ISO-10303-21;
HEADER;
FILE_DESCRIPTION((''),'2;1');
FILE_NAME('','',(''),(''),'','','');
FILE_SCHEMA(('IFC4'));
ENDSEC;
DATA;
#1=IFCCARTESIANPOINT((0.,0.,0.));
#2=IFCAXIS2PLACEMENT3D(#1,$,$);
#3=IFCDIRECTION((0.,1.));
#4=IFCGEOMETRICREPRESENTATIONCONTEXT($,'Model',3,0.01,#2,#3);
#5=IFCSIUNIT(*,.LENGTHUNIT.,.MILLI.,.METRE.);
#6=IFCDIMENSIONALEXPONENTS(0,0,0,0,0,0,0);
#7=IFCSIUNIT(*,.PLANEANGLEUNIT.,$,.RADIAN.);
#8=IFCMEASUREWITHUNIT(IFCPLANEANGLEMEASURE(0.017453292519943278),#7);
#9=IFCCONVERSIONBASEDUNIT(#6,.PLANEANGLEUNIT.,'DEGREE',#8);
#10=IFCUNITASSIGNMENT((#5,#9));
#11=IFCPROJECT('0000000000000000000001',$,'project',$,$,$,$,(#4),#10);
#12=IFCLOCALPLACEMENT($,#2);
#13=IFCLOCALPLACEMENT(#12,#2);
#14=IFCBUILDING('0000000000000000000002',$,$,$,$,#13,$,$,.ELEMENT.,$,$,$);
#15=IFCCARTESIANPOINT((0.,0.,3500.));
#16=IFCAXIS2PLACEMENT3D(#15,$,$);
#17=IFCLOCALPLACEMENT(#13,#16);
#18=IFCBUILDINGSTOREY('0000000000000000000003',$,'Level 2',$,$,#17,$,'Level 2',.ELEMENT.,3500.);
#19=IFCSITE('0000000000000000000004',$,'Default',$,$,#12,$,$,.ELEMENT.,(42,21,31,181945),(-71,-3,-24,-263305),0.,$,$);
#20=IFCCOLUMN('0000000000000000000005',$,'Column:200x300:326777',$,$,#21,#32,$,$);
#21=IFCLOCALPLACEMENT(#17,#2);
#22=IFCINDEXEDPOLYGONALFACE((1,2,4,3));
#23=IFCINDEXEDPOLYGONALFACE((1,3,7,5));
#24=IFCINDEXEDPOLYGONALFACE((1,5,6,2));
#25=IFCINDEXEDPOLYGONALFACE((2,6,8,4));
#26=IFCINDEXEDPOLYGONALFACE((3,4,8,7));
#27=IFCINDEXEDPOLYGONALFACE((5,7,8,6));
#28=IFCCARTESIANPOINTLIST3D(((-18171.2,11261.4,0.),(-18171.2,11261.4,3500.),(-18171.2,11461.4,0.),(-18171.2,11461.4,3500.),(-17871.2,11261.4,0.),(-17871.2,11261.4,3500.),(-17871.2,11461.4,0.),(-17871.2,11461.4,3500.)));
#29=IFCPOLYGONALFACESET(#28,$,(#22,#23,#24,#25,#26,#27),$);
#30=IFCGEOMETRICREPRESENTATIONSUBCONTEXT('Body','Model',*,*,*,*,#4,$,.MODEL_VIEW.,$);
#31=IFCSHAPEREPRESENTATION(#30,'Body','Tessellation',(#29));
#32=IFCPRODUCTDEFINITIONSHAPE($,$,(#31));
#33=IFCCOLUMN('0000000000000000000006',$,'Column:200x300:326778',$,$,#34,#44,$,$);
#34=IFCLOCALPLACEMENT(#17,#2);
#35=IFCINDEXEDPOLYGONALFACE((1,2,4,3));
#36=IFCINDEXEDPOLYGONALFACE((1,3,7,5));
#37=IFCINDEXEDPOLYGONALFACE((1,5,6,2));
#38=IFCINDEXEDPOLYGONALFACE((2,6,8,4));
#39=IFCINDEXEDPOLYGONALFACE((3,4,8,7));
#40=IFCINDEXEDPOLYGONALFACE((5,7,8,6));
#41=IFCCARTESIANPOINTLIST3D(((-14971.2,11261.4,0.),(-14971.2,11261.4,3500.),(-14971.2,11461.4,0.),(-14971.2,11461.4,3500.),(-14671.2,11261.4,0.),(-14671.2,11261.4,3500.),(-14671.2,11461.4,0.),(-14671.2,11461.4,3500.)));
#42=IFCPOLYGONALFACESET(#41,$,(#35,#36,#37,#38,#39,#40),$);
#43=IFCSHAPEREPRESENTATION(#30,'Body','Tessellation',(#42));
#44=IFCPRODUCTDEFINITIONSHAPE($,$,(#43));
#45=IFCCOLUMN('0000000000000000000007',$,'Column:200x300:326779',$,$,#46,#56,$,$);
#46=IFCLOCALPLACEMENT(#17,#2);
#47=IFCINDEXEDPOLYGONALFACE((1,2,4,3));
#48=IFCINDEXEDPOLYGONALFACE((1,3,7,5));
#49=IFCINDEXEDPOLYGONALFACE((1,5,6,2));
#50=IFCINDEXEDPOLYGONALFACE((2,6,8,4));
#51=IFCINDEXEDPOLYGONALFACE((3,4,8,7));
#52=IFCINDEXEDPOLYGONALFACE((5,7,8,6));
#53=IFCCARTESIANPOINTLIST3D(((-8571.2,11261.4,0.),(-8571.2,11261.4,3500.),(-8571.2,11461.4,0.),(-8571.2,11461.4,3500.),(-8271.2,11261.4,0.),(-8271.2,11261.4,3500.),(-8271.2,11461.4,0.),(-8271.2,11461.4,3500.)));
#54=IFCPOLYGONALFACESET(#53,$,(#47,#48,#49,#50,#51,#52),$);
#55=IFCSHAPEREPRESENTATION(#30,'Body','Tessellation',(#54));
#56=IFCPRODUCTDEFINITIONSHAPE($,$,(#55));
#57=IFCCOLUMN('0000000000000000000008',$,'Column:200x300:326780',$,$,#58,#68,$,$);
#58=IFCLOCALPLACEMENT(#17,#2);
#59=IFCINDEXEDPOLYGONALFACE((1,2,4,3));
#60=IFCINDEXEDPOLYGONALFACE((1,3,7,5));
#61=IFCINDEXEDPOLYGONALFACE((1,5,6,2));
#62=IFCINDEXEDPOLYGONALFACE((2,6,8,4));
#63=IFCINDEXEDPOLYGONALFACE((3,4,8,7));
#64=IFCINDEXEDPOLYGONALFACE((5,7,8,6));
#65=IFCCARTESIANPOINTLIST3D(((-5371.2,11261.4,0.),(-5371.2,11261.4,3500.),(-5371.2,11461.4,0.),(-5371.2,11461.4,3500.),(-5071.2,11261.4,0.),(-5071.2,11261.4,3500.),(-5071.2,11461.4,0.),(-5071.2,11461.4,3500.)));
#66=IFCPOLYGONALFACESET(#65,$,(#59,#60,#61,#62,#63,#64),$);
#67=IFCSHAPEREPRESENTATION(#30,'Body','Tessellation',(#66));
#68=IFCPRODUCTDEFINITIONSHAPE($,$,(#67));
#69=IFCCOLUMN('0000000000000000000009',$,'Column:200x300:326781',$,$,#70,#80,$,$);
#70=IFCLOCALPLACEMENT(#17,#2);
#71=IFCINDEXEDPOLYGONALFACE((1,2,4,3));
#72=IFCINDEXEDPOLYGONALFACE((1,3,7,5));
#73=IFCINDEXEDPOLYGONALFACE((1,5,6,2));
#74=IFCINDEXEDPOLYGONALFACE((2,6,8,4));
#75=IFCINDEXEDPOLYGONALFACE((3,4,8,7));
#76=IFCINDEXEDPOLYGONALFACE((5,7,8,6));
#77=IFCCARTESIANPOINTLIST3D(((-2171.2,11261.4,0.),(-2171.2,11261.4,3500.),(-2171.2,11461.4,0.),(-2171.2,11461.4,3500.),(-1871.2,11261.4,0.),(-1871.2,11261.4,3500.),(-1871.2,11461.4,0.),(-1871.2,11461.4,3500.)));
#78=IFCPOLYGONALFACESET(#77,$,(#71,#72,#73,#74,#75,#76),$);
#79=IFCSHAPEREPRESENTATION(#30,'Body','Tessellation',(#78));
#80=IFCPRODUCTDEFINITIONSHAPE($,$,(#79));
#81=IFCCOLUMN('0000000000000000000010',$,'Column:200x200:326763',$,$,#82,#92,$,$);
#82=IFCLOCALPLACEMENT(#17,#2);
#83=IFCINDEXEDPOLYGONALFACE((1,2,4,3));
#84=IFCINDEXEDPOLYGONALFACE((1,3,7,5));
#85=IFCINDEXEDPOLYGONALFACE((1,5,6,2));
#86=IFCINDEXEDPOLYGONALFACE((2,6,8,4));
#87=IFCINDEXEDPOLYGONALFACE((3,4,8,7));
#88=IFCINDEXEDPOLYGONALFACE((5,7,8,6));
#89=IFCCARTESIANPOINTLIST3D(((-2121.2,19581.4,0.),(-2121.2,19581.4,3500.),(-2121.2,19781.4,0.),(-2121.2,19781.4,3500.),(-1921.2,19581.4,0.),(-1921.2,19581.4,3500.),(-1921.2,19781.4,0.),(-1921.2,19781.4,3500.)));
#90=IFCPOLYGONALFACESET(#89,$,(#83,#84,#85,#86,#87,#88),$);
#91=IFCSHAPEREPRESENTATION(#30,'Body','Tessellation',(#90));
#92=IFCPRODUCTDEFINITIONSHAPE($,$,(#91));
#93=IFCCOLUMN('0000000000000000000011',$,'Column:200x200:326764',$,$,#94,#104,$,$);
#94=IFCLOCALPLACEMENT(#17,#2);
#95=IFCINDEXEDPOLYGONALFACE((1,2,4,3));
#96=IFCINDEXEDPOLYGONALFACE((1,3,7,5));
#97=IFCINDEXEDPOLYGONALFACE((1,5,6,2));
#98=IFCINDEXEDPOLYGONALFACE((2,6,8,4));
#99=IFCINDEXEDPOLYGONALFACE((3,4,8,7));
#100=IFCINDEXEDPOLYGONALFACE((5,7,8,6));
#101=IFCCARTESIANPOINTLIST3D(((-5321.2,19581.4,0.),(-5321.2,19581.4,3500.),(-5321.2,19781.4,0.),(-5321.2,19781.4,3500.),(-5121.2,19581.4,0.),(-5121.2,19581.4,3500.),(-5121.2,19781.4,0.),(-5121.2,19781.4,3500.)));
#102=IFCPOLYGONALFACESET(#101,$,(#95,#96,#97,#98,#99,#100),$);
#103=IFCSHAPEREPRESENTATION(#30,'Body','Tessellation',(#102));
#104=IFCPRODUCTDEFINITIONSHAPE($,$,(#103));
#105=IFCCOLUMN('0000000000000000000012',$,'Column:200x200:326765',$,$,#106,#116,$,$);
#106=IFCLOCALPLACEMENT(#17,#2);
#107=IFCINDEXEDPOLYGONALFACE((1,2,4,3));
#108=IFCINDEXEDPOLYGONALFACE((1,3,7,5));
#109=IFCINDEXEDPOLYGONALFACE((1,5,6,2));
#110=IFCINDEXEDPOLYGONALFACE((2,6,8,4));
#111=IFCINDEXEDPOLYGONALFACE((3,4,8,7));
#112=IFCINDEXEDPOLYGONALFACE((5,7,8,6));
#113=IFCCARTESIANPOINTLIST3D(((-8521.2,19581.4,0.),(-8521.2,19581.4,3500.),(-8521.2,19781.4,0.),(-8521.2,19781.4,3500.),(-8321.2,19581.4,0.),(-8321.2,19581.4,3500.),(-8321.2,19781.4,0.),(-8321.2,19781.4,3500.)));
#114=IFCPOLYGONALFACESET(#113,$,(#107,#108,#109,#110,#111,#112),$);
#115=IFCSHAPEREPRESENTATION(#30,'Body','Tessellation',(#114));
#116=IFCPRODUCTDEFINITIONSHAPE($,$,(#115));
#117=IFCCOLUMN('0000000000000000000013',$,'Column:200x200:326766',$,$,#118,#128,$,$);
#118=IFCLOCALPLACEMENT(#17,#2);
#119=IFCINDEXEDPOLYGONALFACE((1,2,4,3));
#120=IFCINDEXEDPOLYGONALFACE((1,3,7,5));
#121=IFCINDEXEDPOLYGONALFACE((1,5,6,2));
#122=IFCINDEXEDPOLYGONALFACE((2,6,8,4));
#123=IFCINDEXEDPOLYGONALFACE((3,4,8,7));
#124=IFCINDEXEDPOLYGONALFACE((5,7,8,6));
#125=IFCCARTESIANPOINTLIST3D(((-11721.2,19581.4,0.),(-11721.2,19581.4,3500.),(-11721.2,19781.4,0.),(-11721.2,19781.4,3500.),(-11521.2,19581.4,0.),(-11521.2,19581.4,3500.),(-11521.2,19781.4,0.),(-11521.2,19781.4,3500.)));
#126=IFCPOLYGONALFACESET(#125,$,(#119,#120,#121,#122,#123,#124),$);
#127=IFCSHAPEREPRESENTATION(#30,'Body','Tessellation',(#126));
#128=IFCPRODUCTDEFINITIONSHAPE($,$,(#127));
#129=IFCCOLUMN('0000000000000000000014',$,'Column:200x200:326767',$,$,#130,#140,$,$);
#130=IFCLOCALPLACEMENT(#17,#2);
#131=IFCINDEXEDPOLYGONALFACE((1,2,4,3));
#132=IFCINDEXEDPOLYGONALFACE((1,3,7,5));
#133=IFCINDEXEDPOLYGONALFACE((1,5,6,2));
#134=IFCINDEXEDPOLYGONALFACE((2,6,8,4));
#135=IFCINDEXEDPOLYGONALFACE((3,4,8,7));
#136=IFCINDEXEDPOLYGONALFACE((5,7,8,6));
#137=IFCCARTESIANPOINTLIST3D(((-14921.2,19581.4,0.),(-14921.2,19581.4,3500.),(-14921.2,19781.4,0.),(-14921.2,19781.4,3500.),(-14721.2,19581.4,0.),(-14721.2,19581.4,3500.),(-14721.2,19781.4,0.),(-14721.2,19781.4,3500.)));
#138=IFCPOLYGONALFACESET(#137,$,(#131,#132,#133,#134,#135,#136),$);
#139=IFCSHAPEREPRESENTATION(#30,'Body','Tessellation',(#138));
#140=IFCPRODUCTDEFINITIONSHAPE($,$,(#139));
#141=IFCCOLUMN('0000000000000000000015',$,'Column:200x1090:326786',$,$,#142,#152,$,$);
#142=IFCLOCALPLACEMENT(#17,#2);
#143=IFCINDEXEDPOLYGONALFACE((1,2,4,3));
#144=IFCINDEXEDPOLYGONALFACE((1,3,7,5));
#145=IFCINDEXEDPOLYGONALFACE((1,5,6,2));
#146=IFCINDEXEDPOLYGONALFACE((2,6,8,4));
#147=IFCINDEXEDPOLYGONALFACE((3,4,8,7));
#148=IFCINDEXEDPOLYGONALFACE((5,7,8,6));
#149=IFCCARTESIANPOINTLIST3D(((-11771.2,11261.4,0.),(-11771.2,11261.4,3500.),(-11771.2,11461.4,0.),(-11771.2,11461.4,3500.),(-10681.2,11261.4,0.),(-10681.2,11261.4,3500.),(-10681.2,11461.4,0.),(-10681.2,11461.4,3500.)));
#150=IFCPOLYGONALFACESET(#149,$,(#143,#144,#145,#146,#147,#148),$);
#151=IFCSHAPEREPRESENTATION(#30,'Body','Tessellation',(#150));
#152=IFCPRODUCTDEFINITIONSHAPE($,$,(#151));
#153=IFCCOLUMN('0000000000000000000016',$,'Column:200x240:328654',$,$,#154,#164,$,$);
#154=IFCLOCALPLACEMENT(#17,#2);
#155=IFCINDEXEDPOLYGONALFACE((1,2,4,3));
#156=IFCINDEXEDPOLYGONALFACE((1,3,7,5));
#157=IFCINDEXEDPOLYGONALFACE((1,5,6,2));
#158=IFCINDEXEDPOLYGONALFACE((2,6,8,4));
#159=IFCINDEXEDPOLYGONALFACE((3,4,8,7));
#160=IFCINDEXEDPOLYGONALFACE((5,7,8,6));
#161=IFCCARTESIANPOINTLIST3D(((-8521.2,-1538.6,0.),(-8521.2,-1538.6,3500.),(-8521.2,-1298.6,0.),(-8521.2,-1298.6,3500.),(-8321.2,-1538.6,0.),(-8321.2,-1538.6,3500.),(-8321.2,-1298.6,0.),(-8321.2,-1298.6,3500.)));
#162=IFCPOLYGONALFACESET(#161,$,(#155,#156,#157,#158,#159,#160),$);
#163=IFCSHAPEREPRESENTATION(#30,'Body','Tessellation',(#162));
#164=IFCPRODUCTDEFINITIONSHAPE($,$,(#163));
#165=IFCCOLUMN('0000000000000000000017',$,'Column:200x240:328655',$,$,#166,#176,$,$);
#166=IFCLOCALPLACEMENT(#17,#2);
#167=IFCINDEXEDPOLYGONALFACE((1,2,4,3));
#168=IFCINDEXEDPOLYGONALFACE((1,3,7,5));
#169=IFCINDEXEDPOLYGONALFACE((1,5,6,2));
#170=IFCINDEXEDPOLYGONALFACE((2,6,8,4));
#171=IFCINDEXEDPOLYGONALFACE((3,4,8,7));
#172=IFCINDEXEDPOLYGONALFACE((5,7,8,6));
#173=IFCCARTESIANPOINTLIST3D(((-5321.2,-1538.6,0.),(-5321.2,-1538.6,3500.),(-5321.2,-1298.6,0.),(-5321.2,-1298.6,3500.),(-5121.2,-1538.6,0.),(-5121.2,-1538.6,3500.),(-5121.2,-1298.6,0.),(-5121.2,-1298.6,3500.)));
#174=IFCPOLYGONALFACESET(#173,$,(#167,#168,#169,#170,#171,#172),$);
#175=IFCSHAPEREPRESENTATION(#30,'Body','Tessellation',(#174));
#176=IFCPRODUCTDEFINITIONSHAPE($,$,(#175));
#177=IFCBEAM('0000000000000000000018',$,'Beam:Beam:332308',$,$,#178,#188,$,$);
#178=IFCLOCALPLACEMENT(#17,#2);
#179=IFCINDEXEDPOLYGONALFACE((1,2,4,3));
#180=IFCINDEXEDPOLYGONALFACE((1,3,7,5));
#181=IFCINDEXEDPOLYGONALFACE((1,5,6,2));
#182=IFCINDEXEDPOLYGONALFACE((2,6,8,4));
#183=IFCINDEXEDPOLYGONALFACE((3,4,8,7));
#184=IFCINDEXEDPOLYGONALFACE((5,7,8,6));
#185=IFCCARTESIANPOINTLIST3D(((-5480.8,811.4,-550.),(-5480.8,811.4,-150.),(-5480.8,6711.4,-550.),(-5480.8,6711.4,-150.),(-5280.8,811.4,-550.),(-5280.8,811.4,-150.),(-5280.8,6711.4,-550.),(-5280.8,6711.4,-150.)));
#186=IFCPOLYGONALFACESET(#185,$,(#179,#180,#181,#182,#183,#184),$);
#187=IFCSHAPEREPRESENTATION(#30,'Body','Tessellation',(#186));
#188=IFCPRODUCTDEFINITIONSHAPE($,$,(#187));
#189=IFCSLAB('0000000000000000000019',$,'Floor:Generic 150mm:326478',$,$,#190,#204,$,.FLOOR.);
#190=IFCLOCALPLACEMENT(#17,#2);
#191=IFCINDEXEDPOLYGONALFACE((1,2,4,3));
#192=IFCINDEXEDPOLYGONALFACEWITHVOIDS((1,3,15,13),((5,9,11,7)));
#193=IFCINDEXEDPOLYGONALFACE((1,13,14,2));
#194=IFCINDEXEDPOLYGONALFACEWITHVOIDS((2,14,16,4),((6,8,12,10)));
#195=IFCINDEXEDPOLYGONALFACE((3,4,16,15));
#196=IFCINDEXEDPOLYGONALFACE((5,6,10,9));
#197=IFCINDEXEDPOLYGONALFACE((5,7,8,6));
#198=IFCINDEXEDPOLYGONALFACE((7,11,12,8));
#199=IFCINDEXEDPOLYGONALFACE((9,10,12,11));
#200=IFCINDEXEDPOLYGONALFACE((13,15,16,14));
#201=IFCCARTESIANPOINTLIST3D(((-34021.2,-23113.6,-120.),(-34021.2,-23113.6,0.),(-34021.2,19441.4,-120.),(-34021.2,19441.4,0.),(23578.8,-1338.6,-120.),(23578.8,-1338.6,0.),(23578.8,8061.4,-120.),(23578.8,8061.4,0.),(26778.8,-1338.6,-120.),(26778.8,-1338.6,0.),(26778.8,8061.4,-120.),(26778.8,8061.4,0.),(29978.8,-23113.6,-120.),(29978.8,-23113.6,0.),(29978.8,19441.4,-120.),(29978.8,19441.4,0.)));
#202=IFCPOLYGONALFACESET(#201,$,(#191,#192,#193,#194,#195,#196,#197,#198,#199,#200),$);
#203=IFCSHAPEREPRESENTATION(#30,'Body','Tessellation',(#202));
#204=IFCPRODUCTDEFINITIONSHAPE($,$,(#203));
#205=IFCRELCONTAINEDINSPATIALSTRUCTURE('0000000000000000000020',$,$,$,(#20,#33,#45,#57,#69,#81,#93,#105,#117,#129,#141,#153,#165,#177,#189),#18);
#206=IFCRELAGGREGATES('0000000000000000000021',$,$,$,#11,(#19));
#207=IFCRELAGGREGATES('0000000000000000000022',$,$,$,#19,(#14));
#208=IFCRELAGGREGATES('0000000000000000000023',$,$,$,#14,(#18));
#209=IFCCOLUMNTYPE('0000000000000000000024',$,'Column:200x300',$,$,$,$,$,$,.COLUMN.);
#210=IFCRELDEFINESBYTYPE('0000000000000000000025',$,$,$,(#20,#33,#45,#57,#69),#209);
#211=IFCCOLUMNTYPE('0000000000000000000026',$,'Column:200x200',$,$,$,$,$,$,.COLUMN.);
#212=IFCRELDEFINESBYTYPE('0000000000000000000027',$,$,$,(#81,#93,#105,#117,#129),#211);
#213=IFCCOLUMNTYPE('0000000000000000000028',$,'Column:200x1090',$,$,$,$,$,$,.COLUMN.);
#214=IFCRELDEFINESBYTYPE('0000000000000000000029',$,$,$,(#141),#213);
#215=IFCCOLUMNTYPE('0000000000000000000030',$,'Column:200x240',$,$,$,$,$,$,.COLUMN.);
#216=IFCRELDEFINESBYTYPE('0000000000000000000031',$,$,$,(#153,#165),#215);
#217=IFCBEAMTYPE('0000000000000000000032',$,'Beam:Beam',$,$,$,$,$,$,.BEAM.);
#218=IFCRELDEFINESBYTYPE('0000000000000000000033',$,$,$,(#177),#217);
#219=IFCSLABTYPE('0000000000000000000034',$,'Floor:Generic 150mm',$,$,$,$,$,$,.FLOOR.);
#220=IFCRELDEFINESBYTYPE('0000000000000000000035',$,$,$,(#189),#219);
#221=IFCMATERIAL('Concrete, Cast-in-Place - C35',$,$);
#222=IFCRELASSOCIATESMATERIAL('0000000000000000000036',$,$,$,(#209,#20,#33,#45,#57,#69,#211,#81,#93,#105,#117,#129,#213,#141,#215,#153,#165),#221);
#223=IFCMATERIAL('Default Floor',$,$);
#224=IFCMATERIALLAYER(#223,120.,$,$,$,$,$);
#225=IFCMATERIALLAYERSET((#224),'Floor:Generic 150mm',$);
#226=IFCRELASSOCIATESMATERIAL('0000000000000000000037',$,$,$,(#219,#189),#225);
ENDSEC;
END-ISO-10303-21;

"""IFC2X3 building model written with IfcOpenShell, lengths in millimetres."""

from ifc_helpers import new_model, entity, si_unit, converted_unit, direction, frame, frame_2d, origin, origin_2d_with_axis, place, context, subcontext, project, spatial, rectangle, extrude, boolean, source, transform, mapped, material, layer, layer_set, layer_usage, type_object, type_shapes, element, save


model = new_model("IFC2X3")

# Units and contexts
model_context = context("Model", 3, precision=0.01, world=origin(), true_north=direction((0.0, 1.0)))
body_context = subcontext(model_context, "Body", "Model", "MODEL_VIEW")
ifc_project = project(units=[si_unit("LENGTHUNIT", "METRE", prefix="MILLI"), converted_unit("PLANEANGLEUNIT", "DEGREE", entity("IfcPlaneAngleMeasure", 0.017453292519943278), si_unit("PLANEANGLEUNIT", "RADIAN"), dimensions=[0, 0, 0, 0, 0, 0, 0])], contexts=[model_context])

# Site, building, storey
site_placement = place(None, origin())
site = spatial("IfcSite", under=ifc_project, at=site_placement, Name="Default", CompositionType="ELEMENT", RefLatitude=(42, 21, 31, 181945), RefLongitude=(-71, -3, -24, -263305), RefElevation=0.0)
building_placement = place(site_placement, origin())
building = spatial("IfcBuilding", under=site, at=building_placement, CompositionType="ELEMENT")
storey_placement = place(building_placement, frame((0.0, 0.0, 3500.0)))
storey = spatial("IfcBuildingStorey", under=building, at=storey_placement, Name="Level 2", LongName="Level 2", CompositionType="ELEMENT", Elevation=3500.0)

# Columns
ifc_material_1 = material(Name="Concrete, Cast-in-Place - C35")
column_type_1 = type_object("IfcColumnType", Name="Column:200x300", PredefinedType="COLUMN", material=ifc_material_1)
shared_shape_1 = source(origin(), body_context, "Body", "SweptSolid", [
    extrude(rectangle(XDim=300.0, YDim=200.0, at=origin_2d_with_axis()), frame((-50.0, 0.0, 3500.0), z_axis=(0.0, 0.0, 1.0), x_axis=(-1.0, 0.0, 0.0)), (0.0, 0.0, 1.0), 3500.0),
])
type_shapes(column_type_1, [shared_shape_1])
for number, where, name in (
    (1, (-17971.2, 11361.4, -3500.0), "Column:200x300:326777"),
    (2, (-14771.2, 11361.4, -3500.0), "Column:200x300:326778"),
    (3, (-8371.2, 11361.4, -3500.0), "Column:200x300:326779"),
    (4, (-5171.2, 11361.4, -3500.0), "Column:200x300:326780"),
    (5, (-1971.2, 11361.4, -3500.0), "Column:200x300:326781"),
):
    element("IfcColumn", number, at=place(storey_placement, frame(where)), inside=storey, type_object=column_type_1, material=ifc_material_1, Name=name, context=body_context, shape_type="MappedRepresentation", body=[
        mapped(shared_shape_1, transform((0.0, 0.0, 0.0), scale=1.0)),
    ])
column_type_2 = type_object("IfcColumnType", Name="Column:200x200", PredefinedType="COLUMN", material=ifc_material_1)
shared_shape_2 = source(origin(), body_context, "Body", "SweptSolid", [
    extrude(rectangle(XDim=200.0, YDim=200.0, at=frame_2d((0.0, 0.0), x_axis=(1.0, 0.0))), frame((0.0, 0.0, 3500.0), z_axis=(0.0, 0.0, 1.0), x_axis=(-1.0, 0.0, 0.0)), (0.0, 0.0, 1.0), 3500.0),
])
type_shapes(column_type_2, [shared_shape_2])
for number, where, name in (
    (6, (-2021.2, 19681.4, -3500.0), "Column:200x200:326763"),
    (7, (-5221.2, 19681.4, -3500.0), "Column:200x200:326764"),
    (8, (-8421.2, 19681.4, -3500.0), "Column:200x200:326765"),
    (9, (-11621.2, 19681.4, -3500.0), "Column:200x200:326766"),
    (10, (-14821.2, 19681.4, -3500.0), "Column:200x200:326767"),
):
    element("IfcColumn", number, at=place(storey_placement, frame(where)), inside=storey, type_object=column_type_2, material=ifc_material_1, Name=name, context=body_context, shape_type="MappedRepresentation", body=[
        mapped(shared_shape_2, transform((0.0, 0.0, 0.0), scale=1.0)),
    ])
column_type_3 = type_object("IfcColumnType", Name="Column:200x1090", PredefinedType="COLUMN", material=ifc_material_1)
shared_shape_3 = source(origin(), body_context, "Body", "SweptSolid", [
    extrude(rectangle(XDim=1090.0, YDim=200.0, at=origin_2d_with_axis()), frame((-445.0, 0.0, 3500.0), z_axis=(0.0, 0.0, 1.0), x_axis=(-1.0, 0.0, 0.0)), (0.0, 0.0, 1.0), 3500.0),
])
type_shapes(column_type_3, [shared_shape_3])
column_placement = place(storey_placement, frame((-10781.2, 11361.4, -3500.0)))
element("IfcColumn", 11, at=column_placement, inside=storey, type_object=column_type_3, material=ifc_material_1, Name="Column:200x1090:326786", context=body_context, shape_type="MappedRepresentation", body=[
    mapped(shared_shape_3, transform((0.0, 0.0, 0.0), scale=1.0)),
])
column_type_4 = type_object("IfcColumnType", Name="Column:200x240", PredefinedType="COLUMN", material=ifc_material_1)
shared_shape_4 = source(origin(), body_context, "Body", "SweptSolid", [
    extrude(rectangle(XDim=200.0, YDim=240.0, at=frame_2d((0.0, 0.0), x_axis=(1.0, 0.0))), frame((0.0, 20.0, 3500.0), z_axis=(0.0, 0.0, 1.0), x_axis=(-1.0, 0.0, 0.0)), (0.0, 0.0, 1.0), 3500.0),
])
type_shapes(column_type_4, [shared_shape_4])
for number, where, name in (
    (12, (-8421.2, -1438.6, -3500.0), "Column:200x240:328654"),
    (13, (-5221.2, -1438.6, -3500.0), "Column:200x240:328655"),
):
    element("IfcColumn", number, at=place(storey_placement, frame(where)), inside=storey, type_object=column_type_4, material=ifc_material_1, Name=name, context=body_context, shape_type="MappedRepresentation", body=[
        mapped(shared_shape_4, transform((0.0, 0.0, 0.0), scale=1.0)),
    ])

# Beam
beam_type = type_object("IfcBeamType", Name="Beam:Beam", PredefinedType="BEAM")
beam_1_placement = place(storey_placement, frame((-5405.8, 6711.4, -150.0), z_axis=(0.0, 0.0, 1.0), x_axis=(0.0, -1.0, 0.0)))
element("IfcBeam", 14, at=beam_1_placement, inside=storey, type_object=beam_type, Name="Beam:Beam:332308", context=body_context, shape_type="SweptSolid", body=[
    extrude(rectangle(XDim=400.0, YDim=200.0, at=frame_2d((0.0, 0.0), x_axis=(1.0, 0.0))), frame((0.0, 25.0, -200.0), z_axis=(1.0, 0.0, 0.0), x_axis=(0.0, 0.0, -1.0)), (0.0, 0.0, 1.0), 5900.0),
])

# Slab, opening
ifc_material_2 = material(Name="Default Floor")
ifc_layer = layer(ifc_material_2, 120.0)
ifc_layer_set = layer_set([ifc_layer], Name="Floor:Generic 150mm")
ifc_layer_usage = layer_usage(ifc_layer_set, "AXIS3", "POSITIVE", 0.0)
slab_type = type_object("IfcSlabType", Name="Floor:Generic 150mm", PredefinedType="FLOOR", material=ifc_layer_set)
slab_placement = place(storey_placement, origin())
slab = element("IfcSlab", 15, at=slab_placement, inside=storey, type_object=slab_type, material=ifc_layer_usage, Name="Floor:Generic 150mm:326478", PredefinedType="FLOOR", context=body_context, shape_type="CSG", body=[
    boolean("DIFFERENCE", extrude(rectangle(XDim=42555.0, YDim=64000.0, at=frame_2d((0.0, 0.0), x_axis=(1.0, 0.0))), frame((-2021.2, -1836.1, 0.0), z_axis=(0.0, 0.0, -1.0), x_axis=(0.0, 1.0, 0.0)), (0.0, 0.0, 1.0), 120.0), extrude(rectangle(XDim=9400.0, YDim=3200.0, at=origin_2d_with_axis()), frame((25178.8, 3361.4, -120.0), z_axis=(0.0, 0.0, 1.0), x_axis=(0.0, 1.0, 0.0)), (0.0, 0.0, 1.0), 120.0)),
])
opening_placement = place(slab_placement, origin())
element("IfcOpeningElement", 16, at=opening_placement, cuts=slab, ObjectType="Opening", context=body_context, shape_type="SweptSolid", body=[
    extrude(rectangle(XDim=9400.0, YDim=3200.0, at=frame_2d((25178.8, 3361.4), x_axis=(0.0, -1.0))), origin(), (0.0, 0.0, -1.0), 120.0),
])

save(model, "model.ifc")
